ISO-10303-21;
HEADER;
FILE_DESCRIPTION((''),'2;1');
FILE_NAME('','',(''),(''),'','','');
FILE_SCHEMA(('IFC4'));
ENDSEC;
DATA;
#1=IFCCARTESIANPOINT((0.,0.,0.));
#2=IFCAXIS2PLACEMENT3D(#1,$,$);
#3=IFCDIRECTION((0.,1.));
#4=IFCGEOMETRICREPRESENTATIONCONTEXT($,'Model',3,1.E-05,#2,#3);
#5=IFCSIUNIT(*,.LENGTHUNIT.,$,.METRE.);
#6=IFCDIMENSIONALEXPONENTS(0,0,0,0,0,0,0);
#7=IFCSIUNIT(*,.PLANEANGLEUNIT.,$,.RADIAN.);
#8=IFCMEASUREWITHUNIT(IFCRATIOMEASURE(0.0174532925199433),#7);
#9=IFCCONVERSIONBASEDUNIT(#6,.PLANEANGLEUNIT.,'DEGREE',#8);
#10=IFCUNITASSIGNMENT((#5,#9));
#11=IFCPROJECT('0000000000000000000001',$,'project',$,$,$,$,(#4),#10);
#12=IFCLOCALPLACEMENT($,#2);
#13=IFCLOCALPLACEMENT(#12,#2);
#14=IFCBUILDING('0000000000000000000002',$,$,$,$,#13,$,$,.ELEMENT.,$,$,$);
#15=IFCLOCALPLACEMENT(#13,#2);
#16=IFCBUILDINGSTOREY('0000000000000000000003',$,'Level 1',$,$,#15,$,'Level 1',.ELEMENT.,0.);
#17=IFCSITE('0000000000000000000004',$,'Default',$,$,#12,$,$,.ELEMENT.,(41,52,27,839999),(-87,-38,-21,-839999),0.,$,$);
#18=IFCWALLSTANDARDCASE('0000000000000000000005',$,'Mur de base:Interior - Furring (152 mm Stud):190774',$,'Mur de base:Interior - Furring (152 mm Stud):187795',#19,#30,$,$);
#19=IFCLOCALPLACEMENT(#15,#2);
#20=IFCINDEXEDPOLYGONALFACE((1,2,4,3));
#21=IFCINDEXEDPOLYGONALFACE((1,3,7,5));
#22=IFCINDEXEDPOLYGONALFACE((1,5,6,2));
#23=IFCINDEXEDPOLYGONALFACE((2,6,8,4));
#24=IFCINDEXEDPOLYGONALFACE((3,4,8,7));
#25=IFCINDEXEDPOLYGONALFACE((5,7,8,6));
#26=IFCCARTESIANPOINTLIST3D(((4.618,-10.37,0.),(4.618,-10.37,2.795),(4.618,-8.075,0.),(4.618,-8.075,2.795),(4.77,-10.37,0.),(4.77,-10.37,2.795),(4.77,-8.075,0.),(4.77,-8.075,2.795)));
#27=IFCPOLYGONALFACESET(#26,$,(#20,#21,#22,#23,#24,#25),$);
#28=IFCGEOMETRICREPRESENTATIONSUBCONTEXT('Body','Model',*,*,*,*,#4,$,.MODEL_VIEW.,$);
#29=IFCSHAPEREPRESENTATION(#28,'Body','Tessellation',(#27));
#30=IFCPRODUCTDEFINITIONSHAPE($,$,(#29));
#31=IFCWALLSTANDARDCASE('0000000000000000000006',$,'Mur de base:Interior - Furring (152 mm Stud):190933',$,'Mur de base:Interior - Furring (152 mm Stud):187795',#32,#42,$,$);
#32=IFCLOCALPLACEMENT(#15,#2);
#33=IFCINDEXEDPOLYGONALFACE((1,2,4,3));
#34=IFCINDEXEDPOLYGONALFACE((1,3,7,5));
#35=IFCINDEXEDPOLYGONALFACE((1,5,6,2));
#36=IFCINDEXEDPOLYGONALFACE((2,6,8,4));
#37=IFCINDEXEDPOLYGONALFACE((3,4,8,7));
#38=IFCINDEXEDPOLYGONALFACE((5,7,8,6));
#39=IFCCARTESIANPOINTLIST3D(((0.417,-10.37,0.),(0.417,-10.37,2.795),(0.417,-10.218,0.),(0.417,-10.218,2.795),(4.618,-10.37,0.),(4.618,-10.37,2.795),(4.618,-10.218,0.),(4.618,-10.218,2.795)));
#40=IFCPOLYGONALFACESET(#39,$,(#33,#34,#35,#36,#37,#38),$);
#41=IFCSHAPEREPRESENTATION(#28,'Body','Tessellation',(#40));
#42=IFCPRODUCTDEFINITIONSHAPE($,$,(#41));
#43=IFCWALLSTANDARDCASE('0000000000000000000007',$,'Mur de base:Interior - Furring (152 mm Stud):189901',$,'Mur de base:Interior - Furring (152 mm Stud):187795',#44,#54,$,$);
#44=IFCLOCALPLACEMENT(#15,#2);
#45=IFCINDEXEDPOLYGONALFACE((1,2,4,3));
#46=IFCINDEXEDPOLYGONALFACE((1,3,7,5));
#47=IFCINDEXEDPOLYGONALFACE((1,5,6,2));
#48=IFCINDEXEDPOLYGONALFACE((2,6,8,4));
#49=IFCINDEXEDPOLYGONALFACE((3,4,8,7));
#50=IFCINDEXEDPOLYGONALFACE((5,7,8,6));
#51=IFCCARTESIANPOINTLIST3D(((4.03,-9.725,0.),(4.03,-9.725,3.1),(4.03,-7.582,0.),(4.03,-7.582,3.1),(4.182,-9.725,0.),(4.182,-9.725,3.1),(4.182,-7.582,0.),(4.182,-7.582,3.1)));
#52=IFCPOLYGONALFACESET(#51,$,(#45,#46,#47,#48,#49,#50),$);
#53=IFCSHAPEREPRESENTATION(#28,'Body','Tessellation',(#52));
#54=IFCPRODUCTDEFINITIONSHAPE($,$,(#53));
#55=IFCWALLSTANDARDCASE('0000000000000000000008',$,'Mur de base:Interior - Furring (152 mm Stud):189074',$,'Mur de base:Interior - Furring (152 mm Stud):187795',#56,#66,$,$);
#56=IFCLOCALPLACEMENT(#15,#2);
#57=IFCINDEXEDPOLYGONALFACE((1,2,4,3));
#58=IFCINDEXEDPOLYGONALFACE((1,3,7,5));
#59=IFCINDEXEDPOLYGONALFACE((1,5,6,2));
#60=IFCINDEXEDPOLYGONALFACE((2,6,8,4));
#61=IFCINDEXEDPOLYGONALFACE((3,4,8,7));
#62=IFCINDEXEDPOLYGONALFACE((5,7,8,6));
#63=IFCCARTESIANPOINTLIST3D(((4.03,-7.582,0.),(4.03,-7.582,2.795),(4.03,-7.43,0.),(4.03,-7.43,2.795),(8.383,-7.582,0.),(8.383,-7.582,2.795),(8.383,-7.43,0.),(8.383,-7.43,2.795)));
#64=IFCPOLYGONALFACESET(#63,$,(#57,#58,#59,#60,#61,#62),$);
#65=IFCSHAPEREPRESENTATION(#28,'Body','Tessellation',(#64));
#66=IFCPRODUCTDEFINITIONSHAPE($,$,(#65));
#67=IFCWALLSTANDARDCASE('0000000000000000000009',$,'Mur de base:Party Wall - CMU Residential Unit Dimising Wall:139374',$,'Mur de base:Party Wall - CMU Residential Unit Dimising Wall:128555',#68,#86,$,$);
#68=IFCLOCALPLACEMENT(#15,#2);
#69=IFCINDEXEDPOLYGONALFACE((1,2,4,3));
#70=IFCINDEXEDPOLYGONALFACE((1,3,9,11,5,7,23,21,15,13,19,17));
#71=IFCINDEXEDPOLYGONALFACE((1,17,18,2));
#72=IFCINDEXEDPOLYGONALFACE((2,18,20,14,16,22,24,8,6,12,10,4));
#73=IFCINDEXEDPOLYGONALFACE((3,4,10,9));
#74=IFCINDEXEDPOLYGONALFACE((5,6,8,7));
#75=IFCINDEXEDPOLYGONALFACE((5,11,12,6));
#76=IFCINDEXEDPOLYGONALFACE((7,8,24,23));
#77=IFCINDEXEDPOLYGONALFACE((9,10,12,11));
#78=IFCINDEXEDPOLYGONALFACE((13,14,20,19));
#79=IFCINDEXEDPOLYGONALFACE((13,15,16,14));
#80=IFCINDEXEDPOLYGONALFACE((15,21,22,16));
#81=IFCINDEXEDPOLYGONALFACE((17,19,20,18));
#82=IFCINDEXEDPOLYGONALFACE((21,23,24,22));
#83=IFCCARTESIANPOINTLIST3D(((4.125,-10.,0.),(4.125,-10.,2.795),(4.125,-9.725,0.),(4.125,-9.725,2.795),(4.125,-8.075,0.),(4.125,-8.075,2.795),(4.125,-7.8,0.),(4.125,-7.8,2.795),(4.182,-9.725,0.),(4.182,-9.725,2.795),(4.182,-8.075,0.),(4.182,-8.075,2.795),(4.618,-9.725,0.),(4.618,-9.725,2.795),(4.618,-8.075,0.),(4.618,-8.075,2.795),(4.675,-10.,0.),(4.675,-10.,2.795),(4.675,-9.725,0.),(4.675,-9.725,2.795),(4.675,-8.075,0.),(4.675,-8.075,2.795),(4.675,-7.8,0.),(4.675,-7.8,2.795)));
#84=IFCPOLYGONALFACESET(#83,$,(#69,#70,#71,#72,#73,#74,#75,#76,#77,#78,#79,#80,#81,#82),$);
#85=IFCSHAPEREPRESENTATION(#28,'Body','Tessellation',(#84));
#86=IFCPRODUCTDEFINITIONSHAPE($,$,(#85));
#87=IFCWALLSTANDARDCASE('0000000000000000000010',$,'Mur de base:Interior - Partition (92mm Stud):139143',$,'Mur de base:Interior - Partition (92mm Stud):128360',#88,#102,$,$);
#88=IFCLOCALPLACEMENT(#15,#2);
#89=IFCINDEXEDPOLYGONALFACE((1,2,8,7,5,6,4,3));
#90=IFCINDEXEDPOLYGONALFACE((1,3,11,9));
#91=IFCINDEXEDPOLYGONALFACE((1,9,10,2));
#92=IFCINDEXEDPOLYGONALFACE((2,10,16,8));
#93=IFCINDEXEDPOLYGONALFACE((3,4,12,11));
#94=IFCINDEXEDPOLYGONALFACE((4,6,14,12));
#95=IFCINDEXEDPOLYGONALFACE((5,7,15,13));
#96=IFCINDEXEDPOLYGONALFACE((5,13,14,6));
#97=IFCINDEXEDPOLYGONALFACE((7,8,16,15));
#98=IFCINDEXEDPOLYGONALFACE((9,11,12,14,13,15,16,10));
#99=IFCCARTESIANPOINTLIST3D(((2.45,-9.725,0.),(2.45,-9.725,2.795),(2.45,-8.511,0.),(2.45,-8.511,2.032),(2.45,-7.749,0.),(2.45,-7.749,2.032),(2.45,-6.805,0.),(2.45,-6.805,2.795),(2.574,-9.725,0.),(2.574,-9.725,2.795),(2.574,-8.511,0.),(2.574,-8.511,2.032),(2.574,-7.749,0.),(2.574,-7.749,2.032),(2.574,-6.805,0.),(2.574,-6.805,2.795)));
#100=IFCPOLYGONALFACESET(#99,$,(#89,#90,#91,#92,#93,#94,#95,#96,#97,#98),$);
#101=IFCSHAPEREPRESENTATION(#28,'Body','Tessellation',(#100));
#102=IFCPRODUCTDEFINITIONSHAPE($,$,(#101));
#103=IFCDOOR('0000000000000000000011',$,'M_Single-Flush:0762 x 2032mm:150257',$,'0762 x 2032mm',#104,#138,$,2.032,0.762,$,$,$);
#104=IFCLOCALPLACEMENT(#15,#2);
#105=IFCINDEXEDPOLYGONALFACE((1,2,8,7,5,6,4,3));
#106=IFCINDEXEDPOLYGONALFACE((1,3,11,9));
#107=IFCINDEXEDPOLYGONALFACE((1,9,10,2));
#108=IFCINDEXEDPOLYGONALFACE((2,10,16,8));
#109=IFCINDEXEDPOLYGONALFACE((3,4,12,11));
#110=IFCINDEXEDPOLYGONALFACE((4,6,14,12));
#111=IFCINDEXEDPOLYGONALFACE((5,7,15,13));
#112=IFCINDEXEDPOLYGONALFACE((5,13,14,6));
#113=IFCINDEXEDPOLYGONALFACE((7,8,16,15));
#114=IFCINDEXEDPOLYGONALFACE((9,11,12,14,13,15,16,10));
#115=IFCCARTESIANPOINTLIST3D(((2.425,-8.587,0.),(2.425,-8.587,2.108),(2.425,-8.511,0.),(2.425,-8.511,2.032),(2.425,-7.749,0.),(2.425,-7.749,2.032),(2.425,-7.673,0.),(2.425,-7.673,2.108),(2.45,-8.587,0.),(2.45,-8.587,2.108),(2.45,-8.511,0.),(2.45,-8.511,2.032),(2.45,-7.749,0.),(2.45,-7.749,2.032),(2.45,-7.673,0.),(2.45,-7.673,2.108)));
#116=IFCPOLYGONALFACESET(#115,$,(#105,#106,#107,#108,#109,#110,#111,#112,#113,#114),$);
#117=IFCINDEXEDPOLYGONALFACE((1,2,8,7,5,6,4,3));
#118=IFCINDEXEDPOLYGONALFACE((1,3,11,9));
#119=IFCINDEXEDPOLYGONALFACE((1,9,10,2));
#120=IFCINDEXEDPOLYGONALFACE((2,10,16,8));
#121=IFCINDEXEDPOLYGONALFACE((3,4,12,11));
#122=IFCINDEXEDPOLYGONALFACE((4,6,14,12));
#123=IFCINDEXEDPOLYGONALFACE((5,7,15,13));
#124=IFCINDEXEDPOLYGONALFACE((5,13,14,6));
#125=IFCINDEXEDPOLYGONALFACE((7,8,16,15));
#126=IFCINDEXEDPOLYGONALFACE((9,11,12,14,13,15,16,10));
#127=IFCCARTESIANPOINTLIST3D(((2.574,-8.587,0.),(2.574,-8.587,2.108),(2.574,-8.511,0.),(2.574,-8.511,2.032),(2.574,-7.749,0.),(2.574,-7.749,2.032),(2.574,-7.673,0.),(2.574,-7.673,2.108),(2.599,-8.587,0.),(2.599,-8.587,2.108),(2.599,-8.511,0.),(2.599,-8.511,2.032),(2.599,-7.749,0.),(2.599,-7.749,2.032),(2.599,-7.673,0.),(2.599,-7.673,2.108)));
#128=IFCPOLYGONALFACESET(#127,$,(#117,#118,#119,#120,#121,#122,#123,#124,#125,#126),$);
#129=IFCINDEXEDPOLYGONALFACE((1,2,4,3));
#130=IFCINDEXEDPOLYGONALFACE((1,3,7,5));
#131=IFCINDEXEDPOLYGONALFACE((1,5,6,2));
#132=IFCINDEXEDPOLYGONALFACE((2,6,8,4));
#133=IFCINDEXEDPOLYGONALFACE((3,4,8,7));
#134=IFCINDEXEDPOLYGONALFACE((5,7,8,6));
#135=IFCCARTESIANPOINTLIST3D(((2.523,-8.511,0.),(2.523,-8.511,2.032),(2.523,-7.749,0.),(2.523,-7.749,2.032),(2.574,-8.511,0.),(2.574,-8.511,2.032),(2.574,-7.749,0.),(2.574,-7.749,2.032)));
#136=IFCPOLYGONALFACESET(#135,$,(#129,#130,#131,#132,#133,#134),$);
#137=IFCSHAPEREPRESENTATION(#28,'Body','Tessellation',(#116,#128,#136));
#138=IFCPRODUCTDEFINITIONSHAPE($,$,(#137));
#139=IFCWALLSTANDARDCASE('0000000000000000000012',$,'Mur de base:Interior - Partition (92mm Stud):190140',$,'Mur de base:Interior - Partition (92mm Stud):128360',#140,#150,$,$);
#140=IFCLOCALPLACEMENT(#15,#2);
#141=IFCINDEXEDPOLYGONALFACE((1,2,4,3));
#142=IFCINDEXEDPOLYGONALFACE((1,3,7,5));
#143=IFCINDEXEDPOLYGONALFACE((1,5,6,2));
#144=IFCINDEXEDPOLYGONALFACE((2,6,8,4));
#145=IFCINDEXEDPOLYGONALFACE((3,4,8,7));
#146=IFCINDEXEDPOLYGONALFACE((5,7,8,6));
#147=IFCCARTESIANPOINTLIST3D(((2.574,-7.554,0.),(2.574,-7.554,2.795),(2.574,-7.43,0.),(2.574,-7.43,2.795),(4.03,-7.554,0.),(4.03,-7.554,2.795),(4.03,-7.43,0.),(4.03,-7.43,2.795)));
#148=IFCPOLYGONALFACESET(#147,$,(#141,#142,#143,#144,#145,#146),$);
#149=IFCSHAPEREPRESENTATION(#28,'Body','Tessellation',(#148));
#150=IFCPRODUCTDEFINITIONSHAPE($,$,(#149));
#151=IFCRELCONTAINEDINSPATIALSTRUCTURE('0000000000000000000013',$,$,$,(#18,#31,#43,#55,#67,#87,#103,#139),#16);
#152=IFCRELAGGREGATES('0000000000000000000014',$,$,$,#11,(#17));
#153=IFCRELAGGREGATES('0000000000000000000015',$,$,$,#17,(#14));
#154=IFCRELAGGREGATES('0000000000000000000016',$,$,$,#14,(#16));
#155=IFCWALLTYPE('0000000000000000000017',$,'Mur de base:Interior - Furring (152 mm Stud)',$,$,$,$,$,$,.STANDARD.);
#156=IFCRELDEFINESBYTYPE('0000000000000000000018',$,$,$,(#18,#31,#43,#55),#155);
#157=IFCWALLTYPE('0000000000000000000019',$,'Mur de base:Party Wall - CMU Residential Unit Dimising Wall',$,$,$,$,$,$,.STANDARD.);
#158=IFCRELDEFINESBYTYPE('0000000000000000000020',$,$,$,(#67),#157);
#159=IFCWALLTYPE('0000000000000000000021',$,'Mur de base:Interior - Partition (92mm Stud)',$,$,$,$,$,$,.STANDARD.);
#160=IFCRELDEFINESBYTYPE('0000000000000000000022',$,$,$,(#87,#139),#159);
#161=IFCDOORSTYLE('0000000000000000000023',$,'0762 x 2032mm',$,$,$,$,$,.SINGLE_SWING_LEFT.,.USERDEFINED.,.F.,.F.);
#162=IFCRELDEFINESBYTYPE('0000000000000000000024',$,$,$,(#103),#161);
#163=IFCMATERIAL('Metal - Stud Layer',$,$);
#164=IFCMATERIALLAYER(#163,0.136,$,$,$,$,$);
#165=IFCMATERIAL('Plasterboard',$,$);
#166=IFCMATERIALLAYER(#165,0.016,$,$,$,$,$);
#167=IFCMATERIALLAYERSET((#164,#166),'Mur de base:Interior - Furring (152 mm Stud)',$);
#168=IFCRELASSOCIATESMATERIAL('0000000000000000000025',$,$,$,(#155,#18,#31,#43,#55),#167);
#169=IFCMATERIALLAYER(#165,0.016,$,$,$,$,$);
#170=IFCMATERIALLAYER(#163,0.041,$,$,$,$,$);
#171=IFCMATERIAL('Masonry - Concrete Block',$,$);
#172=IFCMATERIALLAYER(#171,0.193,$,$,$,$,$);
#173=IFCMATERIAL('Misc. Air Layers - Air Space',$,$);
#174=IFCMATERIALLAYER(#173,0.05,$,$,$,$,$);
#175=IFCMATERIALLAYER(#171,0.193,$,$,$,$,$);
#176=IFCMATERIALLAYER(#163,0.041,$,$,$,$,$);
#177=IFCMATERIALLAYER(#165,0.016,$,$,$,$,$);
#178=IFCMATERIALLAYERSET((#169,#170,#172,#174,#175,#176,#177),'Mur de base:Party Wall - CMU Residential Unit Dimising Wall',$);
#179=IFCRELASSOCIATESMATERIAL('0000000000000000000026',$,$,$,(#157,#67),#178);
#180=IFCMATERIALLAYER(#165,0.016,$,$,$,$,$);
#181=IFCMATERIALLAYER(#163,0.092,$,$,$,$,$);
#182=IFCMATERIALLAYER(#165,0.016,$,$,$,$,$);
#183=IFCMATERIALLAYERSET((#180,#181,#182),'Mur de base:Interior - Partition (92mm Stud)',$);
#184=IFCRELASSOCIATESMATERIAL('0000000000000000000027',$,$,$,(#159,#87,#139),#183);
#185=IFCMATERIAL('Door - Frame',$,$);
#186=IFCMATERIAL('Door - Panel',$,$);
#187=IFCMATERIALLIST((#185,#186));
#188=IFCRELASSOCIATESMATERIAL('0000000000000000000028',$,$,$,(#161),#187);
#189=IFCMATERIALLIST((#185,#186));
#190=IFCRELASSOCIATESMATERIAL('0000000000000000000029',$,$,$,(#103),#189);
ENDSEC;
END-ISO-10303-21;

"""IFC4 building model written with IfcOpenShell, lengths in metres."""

from ifc_helpers import new_model, entity, si_unit, converted_unit, direction, frame, frame_2d, origin, place, context, subcontext, project, spatial, polyline, rectangle, outline, extrude, clip, bounded_halfspace, source, transform, mapped, material, material_list, layer, layer_set, layer_usage, type_object, type_shapes, element, fill, save


model = new_model("IFC4")

# Units and contexts
model_context = context("Model", 3, precision=1e-05, world=origin(), true_north=direction((0.0, 1.0)))
body_context = subcontext(model_context, "Body", "Model", "MODEL_VIEW")
ifc_project = project(units=[si_unit("LENGTHUNIT", "METRE"), converted_unit("PLANEANGLEUNIT", "DEGREE", entity("IfcRatioMeasure", 0.0174532925199433), si_unit("PLANEANGLEUNIT", "RADIAN"), dimensions=[0, 0, 0, 0, 0, 0, 0])], contexts=[model_context])

# Site, building, storey
site_placement = place(None, origin())
site = spatial("IfcSite", under=ifc_project, at=site_placement, Name="Default", CompositionType="ELEMENT", RefLatitude=(41, 52, 27, 839999), RefLongitude=(-87, -38, -21, -839999), RefElevation=0.0)
building_placement = place(site_placement, origin())
building = spatial("IfcBuilding", under=site, at=building_placement, CompositionType="ELEMENT")
storey_placement = place(building_placement, origin())
storey = spatial("IfcBuildingStorey", under=building, at=storey_placement, Name="Level 1", LongName="Level 1", CompositionType="ELEMENT", Elevation=0.0)

# Walls
ifc_material_1 = material(Name="Metal - Stud Layer")
ifc_layer_1 = layer(ifc_material_1, 0.136)
ifc_material_2 = material(Name="Plasterboard")
ifc_layer_2 = layer(ifc_material_2, 0.016)
ifc_layer_set_1 = layer_set([ifc_layer_1, ifc_layer_2], Name="Mur de base:Interior - Furring (152 mm Stud)")
ifc_layer_usage_1 = layer_usage(ifc_layer_set_1, "AXIS2", "POSITIVE", -0.076)
wall_type_1 = type_object("IfcWallType", Name="Mur de base:Interior - Furring (152 mm Stud)", PredefinedType="STANDARD", material=ifc_layer_set_1)
wall_1_placement = place(storey_placement, frame((4.694, -8.075, 0.0), z_axis=(0.0, 0.0, 1.0), x_axis=(0.0, -1.0, 0.0)))
element("IfcWallStandardCase", 1, at=wall_1_placement, inside=storey, type_object=wall_type_1, material=ifc_layer_usage_1, Name="Mur de base:Interior - Furring (152 mm Stud):190774", ObjectType="Mur de base:Interior - Furring (152 mm Stud):187795", context=body_context, shape_type="SweptSolid", body=[
    extrude(rectangle(XDim=2.295, YDim=0.152, at=frame_2d((1.1475, 0.0), x_axis=(-1.0, 0.0))), origin(), (0.0, 0.0, 1.0), 2.795),
])
ifc_layer_usage_2 = layer_usage(ifc_layer_set_1, "AXIS2", "NEGATIVE", 0.076)
wall_2_placement = place(storey_placement, frame((0.417, -10.294, 0.0)))
element("IfcWallStandardCase", 2, at=wall_2_placement, inside=storey, type_object=wall_type_1, material=ifc_layer_usage_2, Name="Mur de base:Interior - Furring (152 mm Stud):190933", ObjectType="Mur de base:Interior - Furring (152 mm Stud):187795", context=body_context, shape_type="SweptSolid", body=[
    extrude(rectangle(XDim=4.201, YDim=0.152, at=frame_2d((2.1005, 0.0), x_axis=(-1.0, 0.0))), origin(), (0.0, 0.0, 1.0), 2.795),
])
ifc_layer_usage_3 = layer_usage(ifc_layer_set_1, "AXIS2", "POSITIVE", -0.076)
wall_3_placement = place(storey_placement, frame((4.106, -9.725, 0.0), z_axis=(0.0, 0.0, 1.0), x_axis=(0.0, 1.0, 0.0)))
element("IfcWallStandardCase", 3, at=wall_3_placement, inside=storey, type_object=wall_type_1, material=ifc_layer_usage_3, Name="Mur de base:Interior - Furring (152 mm Stud):189901", ObjectType="Mur de base:Interior - Furring (152 mm Stud):187795", context=body_context, shape_type="SweptSolid", body=[
    extrude(rectangle(XDim=2.143, YDim=0.152, at=frame_2d((1.0715, 0.0), x_axis=(-1.0, 0.0))), origin(), (0.0, 0.0, 1.0), 3.1),
])
ifc_layer_usage_4 = layer_usage(ifc_layer_set_1, "AXIS2", "NEGATIVE", 0.076)
wall_4_placement = place(storey_placement, frame((8.383, -7.506, 0.0), z_axis=(0.0, 0.0, 1.0), x_axis=(-1.0, 0.0, 0.0)))
element("IfcWallStandardCase", 4, at=wall_4_placement, inside=storey, type_object=wall_type_1, material=ifc_layer_usage_4, Name="Mur de base:Interior - Furring (152 mm Stud):189074", ObjectType="Mur de base:Interior - Furring (152 mm Stud):187795", context=body_context, shape_type="Clipping", body=[
    clip(extrude(rectangle(XDim=4.353, YDim=0.152, at=frame_2d((2.1765, 0.0), x_axis=(-1.0, 0.0))), origin(), (0.0, 0.0, 1.0), 2.795), bounded_halfspace(frame((0.0, -0.076, 2.795), z_axis=(0.0, 0.0, -1.0), x_axis=(0.0, 1.0, 0.0)), True, frame((0.0, -0.076, 2.795)), polyline([(0.0, 0.0), (3.708, 0.0), (3.708, 0.152), (0.0, 0.152), (0.0, 0.0)]))),
])
ifc_layer_3 = layer(ifc_material_2, 0.016)
ifc_layer_4 = layer(ifc_material_1, 0.041)
ifc_material_3 = material(Name="Masonry - Concrete Block")
ifc_layer_5 = layer(ifc_material_3, 0.193)
ifc_material_4 = material(Name="Misc. Air Layers - Air Space")
ifc_layer_6 = layer(ifc_material_4, 0.05)
ifc_layer_7 = layer(ifc_material_3, 0.193)
ifc_layer_8 = layer(ifc_material_1, 0.041)
ifc_layer_9 = layer(ifc_material_2, 0.016)
ifc_layer_set_2 = layer_set([ifc_layer_3, ifc_layer_4, ifc_layer_5, ifc_layer_6, ifc_layer_7, ifc_layer_8, ifc_layer_9], Name="Mur de base:Party Wall - CMU Residential Unit Dimising Wall")
wall_type_2 = type_object("IfcWallType", Name="Mur de base:Party Wall - CMU Residential Unit Dimising Wall", PredefinedType="STANDARD", material=ifc_layer_set_2)
ifc_layer_usage_5 = layer_usage(ifc_layer_set_2, "AXIS2", "NEGATIVE", 0.275)
wall_5_placement = place(storey_placement, frame((4.4, -10.0, 0.0), z_axis=(0.0, 0.0, 1.0), x_axis=(0.0, 1.0, 0.0)))
element("IfcWallStandardCase", 5, at=wall_5_placement, inside=storey, type_object=wall_type_2, material=ifc_layer_usage_5, Name="Mur de base:Party Wall - CMU Residential Unit Dimising Wall:139374", ObjectType="Mur de base:Party Wall - CMU Residential Unit Dimising Wall:128555", context=body_context, shape_type="Clipping", body=[
    clip(clip(extrude(rectangle(XDim=2.2, YDim=0.55, at=frame_2d((1.1, 0.0), x_axis=(-1.0, 0.0))), origin(), (0.0, 0.0, 1.0), 2.795), bounded_halfspace(frame((1.925, 0.218, 0.0), z_axis=(0.0, -1.0, 0.0), x_axis=(1.0, 0.0, 0.0)), True, frame((1.925, 0.218, 0.0), z_axis=(0.0, -1.0, 0.0), x_axis=(1.0, 0.0, 0.0)), polyline([(0.0, 0.0), (0.0, 2.795), (-1.65, 2.795), (-1.65, 0.0), (0.0, 0.0)]))), bounded_halfspace(frame((0.275, -0.218, 0.0), z_axis=(0.0, 1.0, 0.0), x_axis=(-1.0, 0.0, 0.0)), True, frame((0.275, -0.218, 0.0), z_axis=(0.0, 1.0, 0.0), x_axis=(-1.0, 0.0, 0.0)), polyline([(0.0, 0.0), (0.0, 2.795), (-1.65, 2.795), (-1.65, 0.0), (0.0, 0.0)]))),
])

# Wall, opening, door
ifc_layer_10 = layer(ifc_material_2, 0.016)
ifc_layer_11 = layer(ifc_material_1, 0.092)
ifc_layer_12 = layer(ifc_material_2, 0.016)
ifc_layer_set_3 = layer_set([ifc_layer_10, ifc_layer_11, ifc_layer_12], Name="Mur de base:Interior - Partition (92mm Stud)")
ifc_layer_usage_6 = layer_usage(ifc_layer_set_3, "AXIS2", "NEGATIVE", 0.062)
wall_type_3 = type_object("IfcWallType", Name="Mur de base:Interior - Partition (92mm Stud)", PredefinedType="STANDARD", material=ifc_layer_set_3)
wall_6_placement = place(storey_placement, frame((2.512, -6.805, 0.0), z_axis=(0.0, 0.0, 1.0), x_axis=(0.0, -1.0, 0.0)))
wall_6 = element("IfcWallStandardCase", 6, at=wall_6_placement, inside=storey, type_object=wall_type_3, material=ifc_layer_usage_6, Name="Mur de base:Interior - Partition (92mm Stud):139143", ObjectType="Mur de base:Interior - Partition (92mm Stud):128360", context=body_context, shape_type="SweptSolid", body=[
    extrude(rectangle(XDim=2.92, YDim=0.124, at=frame_2d((1.46, 0.0), x_axis=(-1.0, 0.0))), origin(), (0.0, 0.0, 1.0), 2.795),
])
opening_1_placement = place(wall_6_placement, frame((0.944, -0.062, 0.0)))
opening_1 = element("IfcOpeningElement", 7, at=opening_1_placement, cuts=wall_6, ObjectType="Opening", context=body_context, shape_type="SweptSolid", body=[
    extrude(rectangle(XDim=0.762, YDim=2.032, at=frame_2d((1.016, 0.381), x_axis=(0.0, -1.0))), frame((0.0, 0.0, 0.0), z_axis=(0.0, 1.0, 0.0), x_axis=(0.0, 0.0, 1.0)), (0.0, 0.0, 1.0), 0.124),
])
ifc_material_5 = material(Name="Door - Frame")
ifc_material_6 = material(Name="Door - Panel")
ifc_material_list_1 = material_list([ifc_material_5, ifc_material_6])
ifc_material_list_2 = material_list([ifc_material_5, ifc_material_6])
door_style_1 = type_object("IfcDoorStyle", Name="0762 x 2032mm", ConstructionType="USERDEFINED", OperationType="SINGLE_SWING_LEFT", ParameterTakesPrecedence=False, Sizeable=False, material=ifc_material_list_2)
shared_shape_1 = source(origin(), body_context, "Body", "SweptSolid", [
    extrude(outline(polyline([(-1.073, -0.457), (1.035, -0.457), (1.035, -0.381), (-0.997, -0.381), (-0.997, 0.381), (1.035, 0.381), (1.035, 0.457), (-1.073, 0.457), (-1.073, -0.457)])), frame((0.381, 0.0, 1.035), z_axis=(0.0, -1.0, 0.0), x_axis=(0.0, 0.0, -1.0)), (0.0, 0.0, 1.0), 0.025),
    extrude(outline(polyline([(-0.457, -1.073), (0.457, -1.073), (0.457, 1.035), (0.381, 1.035), (0.381, -0.997), (-0.381, -0.997), (-0.381, 1.035), (-0.457, 1.035), (-0.457, -1.073)])), frame((0.381, 0.149, 1.035), z_axis=(0.0, -1.0, 0.0), x_axis=(-1.0, 0.0, 0.0)), (0.0, 0.0, 1.0), 0.025),
    extrude(rectangle(XDim=0.762, YDim=0.051, at=frame_2d((0.0, 0.0), x_axis=(1.0, 0.0))), frame((0.381, 0.0985, 0.0)), (0.0, 0.0, 1.0), 2.032),
])
type_shapes(door_style_1, [shared_shape_1])
door_1_placement = place(opening_1_placement, origin())
door_1 = element("IfcDoor", 8, at=door_1_placement, inside=storey, type_object=door_style_1, material=ifc_material_list_1, Name="M_Single-Flush:0762 x 2032mm:150257", ObjectType="0762 x 2032mm", OverallHeight=2.032, OverallWidth=0.762, context=body_context, shape_type="MappedRepresentation", body=[
    mapped(shared_shape_1, transform((0.0, 0.0, 0.0), scale=1.0)),
])
fill(opening_1, door_1)

# Wall
ifc_layer_usage_7 = layer_usage(ifc_layer_set_3, "AXIS2", "NEGATIVE", 0.062)
wall_7_placement = place(storey_placement, frame((4.03, -7.492, 0.0), z_axis=(0.0, 0.0, 1.0), x_axis=(-1.0, 0.0, 0.0)))
element("IfcWallStandardCase", 9, at=wall_7_placement, inside=storey, type_object=wall_type_3, material=ifc_layer_usage_7, Name="Mur de base:Interior - Partition (92mm Stud):190140", ObjectType="Mur de base:Interior - Partition (92mm Stud):128360", context=body_context, shape_type="SweptSolid", body=[
    extrude(rectangle(XDim=1.456, YDim=0.124, at=frame_2d((0.728, 0.0), x_axis=(-1.0, 0.0))), origin(), (0.0, 0.0, 1.0), 2.795),
])

save(model, "model.ifc")
